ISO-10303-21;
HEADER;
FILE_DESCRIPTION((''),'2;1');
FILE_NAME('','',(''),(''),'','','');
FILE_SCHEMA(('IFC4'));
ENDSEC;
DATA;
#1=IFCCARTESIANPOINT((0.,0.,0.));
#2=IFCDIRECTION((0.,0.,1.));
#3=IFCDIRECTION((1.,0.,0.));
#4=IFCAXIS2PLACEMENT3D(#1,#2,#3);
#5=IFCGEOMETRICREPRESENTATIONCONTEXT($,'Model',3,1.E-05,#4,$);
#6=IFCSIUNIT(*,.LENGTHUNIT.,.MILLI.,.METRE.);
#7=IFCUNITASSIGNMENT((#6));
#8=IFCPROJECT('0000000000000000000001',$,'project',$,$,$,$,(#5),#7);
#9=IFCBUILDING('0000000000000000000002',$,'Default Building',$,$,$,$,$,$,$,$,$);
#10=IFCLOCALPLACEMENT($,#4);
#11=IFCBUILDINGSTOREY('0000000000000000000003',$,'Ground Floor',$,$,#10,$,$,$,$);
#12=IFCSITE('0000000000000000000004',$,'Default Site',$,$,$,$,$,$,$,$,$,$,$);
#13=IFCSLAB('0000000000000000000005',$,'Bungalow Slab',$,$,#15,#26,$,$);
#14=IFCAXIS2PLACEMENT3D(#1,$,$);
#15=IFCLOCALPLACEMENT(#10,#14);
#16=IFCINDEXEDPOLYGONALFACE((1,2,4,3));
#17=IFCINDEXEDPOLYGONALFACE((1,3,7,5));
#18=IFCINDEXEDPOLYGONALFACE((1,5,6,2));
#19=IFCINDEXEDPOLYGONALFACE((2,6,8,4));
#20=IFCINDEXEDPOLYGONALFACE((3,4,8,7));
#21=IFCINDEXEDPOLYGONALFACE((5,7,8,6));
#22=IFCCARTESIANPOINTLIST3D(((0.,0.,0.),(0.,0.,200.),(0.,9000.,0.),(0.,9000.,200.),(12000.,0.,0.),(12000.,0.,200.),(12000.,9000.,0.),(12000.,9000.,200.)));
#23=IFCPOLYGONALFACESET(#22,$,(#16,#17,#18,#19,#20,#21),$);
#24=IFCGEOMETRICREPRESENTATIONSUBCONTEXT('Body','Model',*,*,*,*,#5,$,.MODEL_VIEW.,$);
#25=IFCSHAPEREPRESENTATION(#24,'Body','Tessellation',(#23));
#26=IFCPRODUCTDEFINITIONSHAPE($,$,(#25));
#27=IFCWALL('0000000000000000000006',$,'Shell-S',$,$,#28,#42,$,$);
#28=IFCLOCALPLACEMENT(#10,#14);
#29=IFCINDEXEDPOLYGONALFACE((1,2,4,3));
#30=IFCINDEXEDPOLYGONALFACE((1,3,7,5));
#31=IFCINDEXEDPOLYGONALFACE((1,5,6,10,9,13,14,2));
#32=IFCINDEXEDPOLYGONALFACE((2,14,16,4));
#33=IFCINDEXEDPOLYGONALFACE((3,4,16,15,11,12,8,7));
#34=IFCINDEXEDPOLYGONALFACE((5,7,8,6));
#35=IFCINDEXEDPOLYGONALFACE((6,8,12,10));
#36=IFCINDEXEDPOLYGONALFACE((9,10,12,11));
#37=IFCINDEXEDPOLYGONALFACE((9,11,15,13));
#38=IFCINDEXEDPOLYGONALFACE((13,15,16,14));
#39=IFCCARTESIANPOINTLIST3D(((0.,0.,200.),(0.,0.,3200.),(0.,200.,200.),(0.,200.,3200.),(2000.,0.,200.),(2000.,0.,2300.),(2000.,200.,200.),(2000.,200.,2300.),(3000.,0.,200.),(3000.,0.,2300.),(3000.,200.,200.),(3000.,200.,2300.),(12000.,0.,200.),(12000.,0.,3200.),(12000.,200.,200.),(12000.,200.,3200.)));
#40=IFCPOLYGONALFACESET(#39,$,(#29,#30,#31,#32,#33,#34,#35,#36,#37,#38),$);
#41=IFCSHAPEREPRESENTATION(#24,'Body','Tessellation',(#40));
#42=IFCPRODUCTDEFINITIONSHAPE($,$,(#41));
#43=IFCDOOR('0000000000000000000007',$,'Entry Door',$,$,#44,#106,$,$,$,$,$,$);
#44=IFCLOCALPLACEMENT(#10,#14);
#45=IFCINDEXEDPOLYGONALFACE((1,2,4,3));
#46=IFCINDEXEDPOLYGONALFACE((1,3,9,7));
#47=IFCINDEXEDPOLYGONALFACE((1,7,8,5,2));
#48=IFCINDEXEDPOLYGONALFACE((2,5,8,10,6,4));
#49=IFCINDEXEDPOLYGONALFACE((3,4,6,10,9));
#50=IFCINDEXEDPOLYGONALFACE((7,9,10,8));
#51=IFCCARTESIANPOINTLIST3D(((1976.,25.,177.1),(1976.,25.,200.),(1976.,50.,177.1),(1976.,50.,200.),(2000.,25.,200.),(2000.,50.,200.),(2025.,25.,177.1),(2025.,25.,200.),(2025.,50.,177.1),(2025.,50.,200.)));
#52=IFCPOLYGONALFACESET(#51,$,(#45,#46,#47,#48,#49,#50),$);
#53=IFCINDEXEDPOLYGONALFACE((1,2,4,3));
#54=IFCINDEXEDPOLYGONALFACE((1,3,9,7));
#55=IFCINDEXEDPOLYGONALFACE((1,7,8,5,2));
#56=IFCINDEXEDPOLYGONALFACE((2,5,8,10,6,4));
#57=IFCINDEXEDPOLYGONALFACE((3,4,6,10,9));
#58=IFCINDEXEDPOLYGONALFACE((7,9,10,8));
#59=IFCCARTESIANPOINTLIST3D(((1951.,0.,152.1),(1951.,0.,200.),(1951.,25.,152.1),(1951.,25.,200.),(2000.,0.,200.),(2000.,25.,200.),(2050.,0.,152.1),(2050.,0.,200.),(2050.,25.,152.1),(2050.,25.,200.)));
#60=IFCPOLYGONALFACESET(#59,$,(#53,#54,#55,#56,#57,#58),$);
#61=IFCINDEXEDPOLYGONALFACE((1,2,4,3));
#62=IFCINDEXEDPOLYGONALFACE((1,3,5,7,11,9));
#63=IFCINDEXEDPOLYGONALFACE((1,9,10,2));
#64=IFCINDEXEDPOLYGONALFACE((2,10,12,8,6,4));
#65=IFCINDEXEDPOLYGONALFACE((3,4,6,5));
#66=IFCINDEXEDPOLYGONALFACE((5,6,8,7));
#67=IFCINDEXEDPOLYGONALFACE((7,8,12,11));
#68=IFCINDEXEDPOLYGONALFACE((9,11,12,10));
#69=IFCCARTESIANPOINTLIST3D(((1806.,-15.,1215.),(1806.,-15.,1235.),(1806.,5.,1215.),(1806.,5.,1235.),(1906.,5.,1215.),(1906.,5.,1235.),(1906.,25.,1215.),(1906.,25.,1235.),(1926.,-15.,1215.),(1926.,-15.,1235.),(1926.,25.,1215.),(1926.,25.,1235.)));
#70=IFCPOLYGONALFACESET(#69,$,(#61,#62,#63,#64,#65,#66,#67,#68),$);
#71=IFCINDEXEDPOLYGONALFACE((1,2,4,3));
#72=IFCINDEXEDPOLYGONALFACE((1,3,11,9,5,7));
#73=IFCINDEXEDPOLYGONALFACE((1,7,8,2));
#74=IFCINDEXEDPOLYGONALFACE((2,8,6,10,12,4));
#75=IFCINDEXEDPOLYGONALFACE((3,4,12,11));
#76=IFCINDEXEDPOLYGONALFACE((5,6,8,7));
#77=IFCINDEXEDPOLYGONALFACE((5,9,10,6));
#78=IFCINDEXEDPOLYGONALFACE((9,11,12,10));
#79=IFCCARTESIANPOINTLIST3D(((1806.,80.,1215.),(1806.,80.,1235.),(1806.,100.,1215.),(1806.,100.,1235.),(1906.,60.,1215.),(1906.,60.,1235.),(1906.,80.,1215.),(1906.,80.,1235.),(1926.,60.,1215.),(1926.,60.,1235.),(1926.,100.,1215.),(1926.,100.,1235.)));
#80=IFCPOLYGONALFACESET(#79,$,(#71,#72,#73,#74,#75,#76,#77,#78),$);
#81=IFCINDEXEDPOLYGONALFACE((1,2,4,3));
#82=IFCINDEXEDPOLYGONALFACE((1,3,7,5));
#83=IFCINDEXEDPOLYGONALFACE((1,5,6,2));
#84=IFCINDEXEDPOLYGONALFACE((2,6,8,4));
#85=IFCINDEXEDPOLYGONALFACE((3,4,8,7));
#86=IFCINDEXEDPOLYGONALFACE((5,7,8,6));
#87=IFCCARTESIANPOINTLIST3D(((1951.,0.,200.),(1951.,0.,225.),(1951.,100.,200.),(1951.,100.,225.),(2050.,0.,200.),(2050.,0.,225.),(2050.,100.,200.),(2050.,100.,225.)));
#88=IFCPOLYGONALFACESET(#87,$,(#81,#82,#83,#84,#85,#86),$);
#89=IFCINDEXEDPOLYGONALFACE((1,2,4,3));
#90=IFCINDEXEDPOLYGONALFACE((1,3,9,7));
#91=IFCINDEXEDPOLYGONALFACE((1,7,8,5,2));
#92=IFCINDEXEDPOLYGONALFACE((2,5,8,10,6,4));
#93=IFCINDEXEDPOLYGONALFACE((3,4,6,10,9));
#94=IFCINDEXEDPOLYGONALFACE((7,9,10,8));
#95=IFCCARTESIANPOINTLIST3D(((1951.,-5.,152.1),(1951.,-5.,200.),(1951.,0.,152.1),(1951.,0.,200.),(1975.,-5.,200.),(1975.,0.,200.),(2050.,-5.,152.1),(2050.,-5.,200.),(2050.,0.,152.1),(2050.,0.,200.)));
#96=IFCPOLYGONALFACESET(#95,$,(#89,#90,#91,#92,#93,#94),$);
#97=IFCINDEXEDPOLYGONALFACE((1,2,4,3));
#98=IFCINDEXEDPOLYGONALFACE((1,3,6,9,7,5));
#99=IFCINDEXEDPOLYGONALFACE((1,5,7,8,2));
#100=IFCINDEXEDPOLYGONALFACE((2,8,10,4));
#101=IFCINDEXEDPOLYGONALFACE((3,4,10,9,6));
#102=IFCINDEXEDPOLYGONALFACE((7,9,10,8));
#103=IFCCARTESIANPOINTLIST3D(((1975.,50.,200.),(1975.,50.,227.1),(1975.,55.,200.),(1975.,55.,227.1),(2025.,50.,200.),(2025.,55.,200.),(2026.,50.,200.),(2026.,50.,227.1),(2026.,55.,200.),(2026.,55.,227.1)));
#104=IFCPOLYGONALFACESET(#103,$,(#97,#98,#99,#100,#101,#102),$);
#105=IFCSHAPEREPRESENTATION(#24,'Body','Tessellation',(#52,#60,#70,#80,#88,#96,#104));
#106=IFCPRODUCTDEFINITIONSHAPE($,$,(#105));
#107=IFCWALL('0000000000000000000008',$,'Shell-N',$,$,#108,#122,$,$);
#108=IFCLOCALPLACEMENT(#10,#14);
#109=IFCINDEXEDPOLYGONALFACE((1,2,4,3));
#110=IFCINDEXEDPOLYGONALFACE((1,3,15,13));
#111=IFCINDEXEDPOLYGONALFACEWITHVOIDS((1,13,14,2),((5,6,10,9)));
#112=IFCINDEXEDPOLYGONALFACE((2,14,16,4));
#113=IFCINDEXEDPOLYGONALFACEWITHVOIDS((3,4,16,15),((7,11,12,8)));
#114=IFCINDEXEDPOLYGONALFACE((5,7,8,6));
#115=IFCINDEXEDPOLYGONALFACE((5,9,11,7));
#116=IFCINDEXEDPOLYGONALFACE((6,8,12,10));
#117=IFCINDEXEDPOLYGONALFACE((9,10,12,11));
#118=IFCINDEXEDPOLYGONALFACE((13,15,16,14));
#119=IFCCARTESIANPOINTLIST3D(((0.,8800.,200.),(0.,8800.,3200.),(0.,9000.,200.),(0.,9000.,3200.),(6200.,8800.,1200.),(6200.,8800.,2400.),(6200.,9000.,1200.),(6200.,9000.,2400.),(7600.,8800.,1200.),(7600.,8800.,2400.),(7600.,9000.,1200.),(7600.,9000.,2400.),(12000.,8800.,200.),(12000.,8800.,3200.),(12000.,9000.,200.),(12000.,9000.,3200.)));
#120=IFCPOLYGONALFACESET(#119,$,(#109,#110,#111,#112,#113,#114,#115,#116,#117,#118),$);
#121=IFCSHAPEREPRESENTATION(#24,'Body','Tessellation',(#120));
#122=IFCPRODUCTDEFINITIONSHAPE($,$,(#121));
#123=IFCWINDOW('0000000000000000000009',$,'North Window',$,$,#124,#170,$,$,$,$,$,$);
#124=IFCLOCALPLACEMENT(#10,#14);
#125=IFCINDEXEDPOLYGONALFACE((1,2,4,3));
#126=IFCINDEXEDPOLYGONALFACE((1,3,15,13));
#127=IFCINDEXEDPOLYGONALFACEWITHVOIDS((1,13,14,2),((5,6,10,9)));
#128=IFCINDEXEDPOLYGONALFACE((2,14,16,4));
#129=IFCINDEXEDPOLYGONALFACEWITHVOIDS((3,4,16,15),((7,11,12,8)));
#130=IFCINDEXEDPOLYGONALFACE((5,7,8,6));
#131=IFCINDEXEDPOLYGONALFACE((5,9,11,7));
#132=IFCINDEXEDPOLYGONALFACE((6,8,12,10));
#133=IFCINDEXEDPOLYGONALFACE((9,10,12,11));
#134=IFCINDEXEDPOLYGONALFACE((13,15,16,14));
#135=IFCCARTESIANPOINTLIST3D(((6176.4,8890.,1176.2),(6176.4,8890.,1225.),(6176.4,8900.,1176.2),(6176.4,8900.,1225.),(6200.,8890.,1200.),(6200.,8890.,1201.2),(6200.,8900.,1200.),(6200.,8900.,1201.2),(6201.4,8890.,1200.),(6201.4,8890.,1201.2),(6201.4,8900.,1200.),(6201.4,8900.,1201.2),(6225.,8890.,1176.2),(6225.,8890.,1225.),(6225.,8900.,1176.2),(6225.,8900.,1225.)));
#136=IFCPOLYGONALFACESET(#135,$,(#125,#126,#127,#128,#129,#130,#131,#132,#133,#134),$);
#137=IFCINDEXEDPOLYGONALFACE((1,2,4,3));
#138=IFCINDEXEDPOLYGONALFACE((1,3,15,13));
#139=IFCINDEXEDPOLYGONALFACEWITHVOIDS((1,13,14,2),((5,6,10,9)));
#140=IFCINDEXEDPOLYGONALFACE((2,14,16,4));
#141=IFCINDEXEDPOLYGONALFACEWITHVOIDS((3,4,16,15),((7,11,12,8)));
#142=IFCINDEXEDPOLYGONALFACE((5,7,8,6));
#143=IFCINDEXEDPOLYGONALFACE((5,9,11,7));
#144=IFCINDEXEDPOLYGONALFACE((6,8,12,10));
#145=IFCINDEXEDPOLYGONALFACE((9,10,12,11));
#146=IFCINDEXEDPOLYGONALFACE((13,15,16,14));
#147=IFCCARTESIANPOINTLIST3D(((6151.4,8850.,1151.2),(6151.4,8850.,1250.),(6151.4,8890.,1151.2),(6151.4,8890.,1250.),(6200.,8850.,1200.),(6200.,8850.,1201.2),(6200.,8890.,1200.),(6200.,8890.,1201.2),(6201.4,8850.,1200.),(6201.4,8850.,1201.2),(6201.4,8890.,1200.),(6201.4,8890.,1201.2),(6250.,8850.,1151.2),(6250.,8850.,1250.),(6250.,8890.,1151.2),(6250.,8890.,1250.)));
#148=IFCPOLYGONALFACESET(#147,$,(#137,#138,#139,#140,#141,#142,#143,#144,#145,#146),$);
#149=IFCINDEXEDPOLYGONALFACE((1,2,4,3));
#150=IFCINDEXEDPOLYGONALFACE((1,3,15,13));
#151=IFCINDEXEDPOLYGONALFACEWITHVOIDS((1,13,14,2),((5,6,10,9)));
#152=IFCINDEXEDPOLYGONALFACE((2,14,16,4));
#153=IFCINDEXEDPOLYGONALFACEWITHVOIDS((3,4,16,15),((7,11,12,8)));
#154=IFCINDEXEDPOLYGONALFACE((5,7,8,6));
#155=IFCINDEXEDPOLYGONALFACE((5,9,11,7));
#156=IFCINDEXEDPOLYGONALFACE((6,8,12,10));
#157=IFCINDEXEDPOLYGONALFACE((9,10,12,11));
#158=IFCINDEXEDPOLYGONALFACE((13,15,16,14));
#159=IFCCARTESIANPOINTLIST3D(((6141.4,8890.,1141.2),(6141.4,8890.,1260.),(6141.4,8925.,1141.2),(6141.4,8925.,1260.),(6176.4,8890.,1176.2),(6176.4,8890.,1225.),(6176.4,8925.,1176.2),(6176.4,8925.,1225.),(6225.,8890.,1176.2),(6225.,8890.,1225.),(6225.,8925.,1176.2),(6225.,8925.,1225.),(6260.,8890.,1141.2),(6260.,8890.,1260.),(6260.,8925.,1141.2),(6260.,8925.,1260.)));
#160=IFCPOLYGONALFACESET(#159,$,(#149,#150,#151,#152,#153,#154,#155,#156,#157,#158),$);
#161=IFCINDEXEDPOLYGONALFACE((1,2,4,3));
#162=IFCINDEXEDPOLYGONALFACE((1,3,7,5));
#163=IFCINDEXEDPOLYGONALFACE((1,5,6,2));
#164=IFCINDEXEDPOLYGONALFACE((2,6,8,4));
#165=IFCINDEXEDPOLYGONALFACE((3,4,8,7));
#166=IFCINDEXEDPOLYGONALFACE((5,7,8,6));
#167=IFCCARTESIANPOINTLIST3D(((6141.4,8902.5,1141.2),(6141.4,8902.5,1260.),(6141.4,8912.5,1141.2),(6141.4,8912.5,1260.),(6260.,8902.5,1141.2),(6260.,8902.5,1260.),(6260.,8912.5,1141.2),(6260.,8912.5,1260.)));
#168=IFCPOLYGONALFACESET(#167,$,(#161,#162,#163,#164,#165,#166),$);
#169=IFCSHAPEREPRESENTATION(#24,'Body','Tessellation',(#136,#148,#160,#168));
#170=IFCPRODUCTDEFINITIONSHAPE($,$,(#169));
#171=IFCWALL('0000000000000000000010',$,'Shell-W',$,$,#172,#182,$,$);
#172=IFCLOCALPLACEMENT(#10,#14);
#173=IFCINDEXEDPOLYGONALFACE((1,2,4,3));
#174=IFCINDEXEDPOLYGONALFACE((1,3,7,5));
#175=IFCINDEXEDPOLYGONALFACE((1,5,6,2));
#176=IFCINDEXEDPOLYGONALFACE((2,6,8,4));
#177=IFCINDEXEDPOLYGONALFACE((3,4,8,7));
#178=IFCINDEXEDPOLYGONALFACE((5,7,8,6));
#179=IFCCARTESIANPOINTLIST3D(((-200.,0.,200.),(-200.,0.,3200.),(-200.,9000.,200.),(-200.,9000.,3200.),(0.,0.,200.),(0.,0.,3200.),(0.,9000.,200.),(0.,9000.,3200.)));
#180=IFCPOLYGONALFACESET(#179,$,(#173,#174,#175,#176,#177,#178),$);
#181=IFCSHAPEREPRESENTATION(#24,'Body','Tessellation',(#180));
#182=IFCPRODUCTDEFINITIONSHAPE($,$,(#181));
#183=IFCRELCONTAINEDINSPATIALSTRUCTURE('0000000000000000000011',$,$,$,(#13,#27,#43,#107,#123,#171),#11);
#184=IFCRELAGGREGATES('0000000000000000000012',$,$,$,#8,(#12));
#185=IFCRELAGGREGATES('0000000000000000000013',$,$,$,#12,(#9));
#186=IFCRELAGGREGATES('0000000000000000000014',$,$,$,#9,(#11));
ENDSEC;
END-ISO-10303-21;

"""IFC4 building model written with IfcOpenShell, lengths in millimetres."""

from ifc_helpers import new_model, si_unit, frame, origin_with_axes, place, context, subcontext, project, spatial, line, indexed_curve, outline, extrude, element, fill, save


model = new_model("IFC4")

# Units and contexts
model_context = context("Model", 3, precision=1e-05, world=origin_with_axes())
body_context = subcontext(model_context, "Body", "Model", "MODEL_VIEW")
ifc_project = project(units=[si_unit("LENGTHUNIT", "METRE", prefix="MILLI")], contexts=[model_context])

# Site, building, storey
site = spatial("IfcSite", under=ifc_project, Name="Default Site")
building = spatial("IfcBuilding", under=site, Name="Default Building")
storey_placement = place(None, origin_with_axes())
storey = spatial("IfcBuildingStorey", under=building, at=storey_placement, Name="Ground Floor")

# Slab
slab_placement = place(storey_placement, origin_with_axes())
element("IfcSlab", 1, at=slab_placement, inside=storey, Name="Bungalow Slab", context=body_context, shape_type="SweptSolid", body=[
    extrude(outline(indexed_curve([(0.0, 0.0), (12000.0, 0.0), (12000.0, 9000.0), (0.0, 9000.0), (0.0, 0.0)])), None, (0.0, 0.0, 1.0), 200.0),
])

# Wall, opening, door
wall_1_placement = place(storey_placement, frame((0.0, 0.0, 200.0), z_axis=(0.0, 0.0, 1.0), x_axis=(1.0, 0.0, 0.0)))
wall_1 = element("IfcWall", 2, at=wall_1_placement, inside=storey, Name="Shell-S", context=body_context, shape_type="SweptSolid", body=[
    extrude(outline(indexed_curve([(0.0, 0.0), (12000.0, 0.0), (12000.0, 200.0), (0.0, 200.0), (0.0, 0.0)])), None, (0.0, 0.0, 1.0), 3000.0),
])
opening_1_placement = place(wall_1_placement, origin_with_axes())
opening_1 = element("IfcOpeningElement", 3, at=opening_1_placement, cuts=wall_1, context=body_context, shape_type="SweptSolid", body=[
    extrude(outline(indexed_curve([(2000.0, 0.0), (3000.0, 0.0), (3000.0, 200.0), (2000.0, 200.0), (2000.0, 0.0)])), None, (0.0, 0.0, 1.0), 2100.0),
])
door_1_placement = place(storey_placement, frame((2000.0, 0.0, 200.0), z_axis=(0.0, 0.0, 1.0), x_axis=(1.0, 0.0, 0.0)))
door_1 = element("IfcDoor", 4, at=door_1_placement, inside=storey, Name="Entry Door", context=body_context, shape_type="SweptSolid", body=[
    extrude(outline(indexed_curve([(0.0, 0.0), (0.0, 2.1), (1.0, 2.1), (1.0, 0.0), (-24.0, 0.0), (-24.0, -22.9), (25.0, -22.9), (25.0, 0.0)], segments=[line(1, 2, 3, 4, 5, 6, 7, 8, 1)])), frame((0.0, 25.0, 0.0), z_axis=(0.0, -1.0, 0.0), x_axis=(1.0, 0.0, 0.0)), (0.0, 0.0, -1.0), 25.0),
    extrude(outline(indexed_curve([(0.0, 0.0), (0.0, 2.1), (1.0, 2.1), (1.0, 0.0), (-49.0, 0.0), (-49.0, -47.9), (50.0, -47.9), (50.0, 0.0)], segments=[line(1, 2, 3, 4, 5, 6, 7, 8, 1)])), frame((0.0, 0.0, 0.0), z_axis=(0.0, -1.0, 0.0), x_axis=(1.0, 0.0, 0.0)), (0.0, 0.0, -1.0), 25.0),
    extrude(outline(indexed_curve([(0.0, 0.0), (-49.0, 0.0), (-49.0, 35.0), (0.0, 35.0)], segments=[line(1, 2, 3, 4, 1)])), frame((25.0, 25.0, 25.0), z_axis=(0.0, 0.0, 1.0), x_axis=(1.0, 0.0, 0.0)), (0.0, 0.0, 1.0), -47.9),
    extrude(outline(indexed_curve([(0.0, 0.0), (0.0, -40.0), (-120.0, -40.0), (-120.0, -20.0), (-20.0, -20.0), (-20.0, 0.0)], segments=[line(1, 2, 3, 4, 5, 6, 1)])), frame((-74.0, 25.0, 1015.0), z_axis=(0.0, 0.0, 1.0), x_axis=(1.0, 0.0, 0.0)), (0.0, 0.0, 1.0), 20.0),
    extrude(outline(indexed_curve([(0.0, 0.0), (0.0, 40.0), (-120.0, 40.0), (-120.0, 20.0), (-20.0, 20.0), (-20.0, 0.0)], segments=[line(1, 2, 3, 4, 5, 6, 1)])), frame((-74.0, 60.0, 1015.0), z_axis=(0.0, 0.0, 1.0), x_axis=(1.0, 0.0, 0.0)), (0.0, 0.0, 1.0), 20.0),
    extrude(outline(indexed_curve([(0.0, 0.0), (-99.0, 0.0), (-99.0, 100.0), (0.0, 100.0)], segments=[line(1, 2, 3, 4, 1)])), frame((50.0, 0.0, 0.0), z_axis=(0.0, 0.0, 1.0), x_axis=(1.0, 0.0, 0.0)), (0.0, 0.0, 1.0), 25.0),
    extrude(outline(indexed_curve([(0.0, 0.0), (0.0, 27.1), (51.0, 27.1), (51.0, 0.0), (-24.0, 0.0), (-24.0, -47.9), (75.0, -47.9), (75.0, 0.0)], segments=[line(1, 2, 3, 4, 5, 6, 7, 8, 1)])), frame((-25.0, -5.0, 0.0), z_axis=(0.0, -1.0, 0.0), x_axis=(1.0, 0.0, 0.0)), (0.0, 0.0, -1.0), 5.0),
    extrude(outline(indexed_curve([(0.0, 0.0), (0.0, 27.1), (51.0, 27.1), (51.0, 0.0), (1.0, 0.0), (1.0, -22.9), (50.0, -22.9), (50.0, 0.0)], segments=[line(1, 2, 3, 4, 5, 6, 7, 8, 1)])), frame((-25.0, 50.0, 0.0), z_axis=(0.0, -1.0, 0.0), x_axis=(1.0, 0.0, 0.0)), (0.0, 0.0, -1.0), 5.0),
])
fill(opening_1, door_1)

# Wall, opening, window
wall_2_placement = place(storey_placement, frame((0.0, 0.0, 200.0), z_axis=(0.0, 0.0, 1.0), x_axis=(1.0, 0.0, 0.0)))
wall_2 = element("IfcWall", 5, at=wall_2_placement, inside=storey, Name="Shell-N", context=body_context, shape_type="SweptSolid", body=[
    extrude(outline(indexed_curve([(0.0, 8800.0), (12000.0, 8800.0), (12000.0, 9000.0), (0.0, 9000.0), (0.0, 8800.0)])), None, (0.0, 0.0, 1.0), 3000.0),
])
opening_2_placement = place(wall_2_placement, frame((0.0, 0.0, 1000.0), z_axis=(0.0, 0.0, 1.0), x_axis=(1.0, 0.0, 0.0)))
opening_2 = element("IfcOpeningElement", 6, at=opening_2_placement, cuts=wall_2, context=body_context, shape_type="SweptSolid", body=[
    extrude(outline(indexed_curve([(6200.0, 8800.0), (7600.0, 8800.0), (7600.0, 9000.0), (6200.0, 9000.0), (6200.0, 8800.0)])), None, (0.0, 0.0, 1.0), 1200.0),
])
window_1_placement = place(storey_placement, frame((6200.0, 8800.0, 1200.0), z_axis=(0.0, 0.0, 1.0), x_axis=(1.0, 0.0, 0.0)))
window_1 = element("IfcWindow", 7, at=window_1_placement, inside=storey, Name="North Window", context=body_context, shape_type="SweptSolid", body=[
    extrude(outline(indexed_curve([(0.0, 0.0), (1.4, 0.0), (1.4, 1.2), (0.0, 1.2)], segments=[line(1, 2, 3, 4, 1)]), holes=[indexed_curve([(25.0, 25.0), (-23.6, 25.0), (-23.6, -23.8), (25.0, -23.8)], segments=[line(1, 2, 3, 4, 1)])]), frame((0.0, 90.0, 0.0), z_axis=(0.0, -1.0, 0.0), x_axis=(1.0, 0.0, 0.0)), (0.0, 0.0, -1.0), 10.0),
    extrude(outline(indexed_curve([(0.0, 0.0), (1.4, 0.0), (1.4, 1.2), (0.0, 1.2)], segments=[line(1, 2, 3, 4, 1)]), holes=[indexed_curve([(50.0, 50.0), (-48.6, 50.0), (-48.6, -48.8), (50.0, -48.8)], segments=[line(1, 2, 3, 4, 1)])]), frame((0.0, 50.0, 0.0), z_axis=(0.0, -1.0, 0.0), x_axis=(1.0, 0.0, 0.0)), (0.0, 0.0, -1.0), 40.0),
    extrude(outline(indexed_curve([(0.0, 0.0), (-48.6, 0.0), (-48.6, -48.8), (0.0, -48.8)], segments=[line(1, 2, 3, 4, 1)]), holes=[indexed_curve([(35.0, 35.0), (-83.6, 35.0), (-83.6, -83.8), (35.0, -83.8)], segments=[line(1, 2, 3, 4, 1)])]), frame((25.0, 90.0, 25.0), z_axis=(0.0, -1.0, 0.0), x_axis=(1.0, 0.0, 0.0)), (0.0, 0.0, -1.0), 35.0),
    extrude(outline(indexed_curve([(35.0, 35.0), (-83.6, 35.0), (-83.6, -83.8), (35.0, -83.8)], segments=[line(1, 2, 3, 4, 1)])), frame((25.0, 102.5, 25.0), z_axis=(0.0, -1.0, 0.0), x_axis=(1.0, 0.0, 0.0)), (0.0, 0.0, -1.0), 10.0),
])
fill(opening_2, window_1)

# Wall
wall_3_placement = place(storey_placement, frame((0.0, 0.0, 200.0), z_axis=(0.0, 0.0, 1.0), x_axis=(1.0, 0.0, 0.0)))
element("IfcWall", 8, at=wall_3_placement, inside=storey, Name="Shell-W", context=body_context, shape_type="SweptSolid", body=[
    extrude(outline(indexed_curve([(0.0, 0.0), (0.0, 9000.0), (-200.0, 9000.0), (-200.0, 0.0), (0.0, 0.0)])), None, (0.0, 0.0, 1.0), 3000.0),
])

save(model, "model.ifc")
